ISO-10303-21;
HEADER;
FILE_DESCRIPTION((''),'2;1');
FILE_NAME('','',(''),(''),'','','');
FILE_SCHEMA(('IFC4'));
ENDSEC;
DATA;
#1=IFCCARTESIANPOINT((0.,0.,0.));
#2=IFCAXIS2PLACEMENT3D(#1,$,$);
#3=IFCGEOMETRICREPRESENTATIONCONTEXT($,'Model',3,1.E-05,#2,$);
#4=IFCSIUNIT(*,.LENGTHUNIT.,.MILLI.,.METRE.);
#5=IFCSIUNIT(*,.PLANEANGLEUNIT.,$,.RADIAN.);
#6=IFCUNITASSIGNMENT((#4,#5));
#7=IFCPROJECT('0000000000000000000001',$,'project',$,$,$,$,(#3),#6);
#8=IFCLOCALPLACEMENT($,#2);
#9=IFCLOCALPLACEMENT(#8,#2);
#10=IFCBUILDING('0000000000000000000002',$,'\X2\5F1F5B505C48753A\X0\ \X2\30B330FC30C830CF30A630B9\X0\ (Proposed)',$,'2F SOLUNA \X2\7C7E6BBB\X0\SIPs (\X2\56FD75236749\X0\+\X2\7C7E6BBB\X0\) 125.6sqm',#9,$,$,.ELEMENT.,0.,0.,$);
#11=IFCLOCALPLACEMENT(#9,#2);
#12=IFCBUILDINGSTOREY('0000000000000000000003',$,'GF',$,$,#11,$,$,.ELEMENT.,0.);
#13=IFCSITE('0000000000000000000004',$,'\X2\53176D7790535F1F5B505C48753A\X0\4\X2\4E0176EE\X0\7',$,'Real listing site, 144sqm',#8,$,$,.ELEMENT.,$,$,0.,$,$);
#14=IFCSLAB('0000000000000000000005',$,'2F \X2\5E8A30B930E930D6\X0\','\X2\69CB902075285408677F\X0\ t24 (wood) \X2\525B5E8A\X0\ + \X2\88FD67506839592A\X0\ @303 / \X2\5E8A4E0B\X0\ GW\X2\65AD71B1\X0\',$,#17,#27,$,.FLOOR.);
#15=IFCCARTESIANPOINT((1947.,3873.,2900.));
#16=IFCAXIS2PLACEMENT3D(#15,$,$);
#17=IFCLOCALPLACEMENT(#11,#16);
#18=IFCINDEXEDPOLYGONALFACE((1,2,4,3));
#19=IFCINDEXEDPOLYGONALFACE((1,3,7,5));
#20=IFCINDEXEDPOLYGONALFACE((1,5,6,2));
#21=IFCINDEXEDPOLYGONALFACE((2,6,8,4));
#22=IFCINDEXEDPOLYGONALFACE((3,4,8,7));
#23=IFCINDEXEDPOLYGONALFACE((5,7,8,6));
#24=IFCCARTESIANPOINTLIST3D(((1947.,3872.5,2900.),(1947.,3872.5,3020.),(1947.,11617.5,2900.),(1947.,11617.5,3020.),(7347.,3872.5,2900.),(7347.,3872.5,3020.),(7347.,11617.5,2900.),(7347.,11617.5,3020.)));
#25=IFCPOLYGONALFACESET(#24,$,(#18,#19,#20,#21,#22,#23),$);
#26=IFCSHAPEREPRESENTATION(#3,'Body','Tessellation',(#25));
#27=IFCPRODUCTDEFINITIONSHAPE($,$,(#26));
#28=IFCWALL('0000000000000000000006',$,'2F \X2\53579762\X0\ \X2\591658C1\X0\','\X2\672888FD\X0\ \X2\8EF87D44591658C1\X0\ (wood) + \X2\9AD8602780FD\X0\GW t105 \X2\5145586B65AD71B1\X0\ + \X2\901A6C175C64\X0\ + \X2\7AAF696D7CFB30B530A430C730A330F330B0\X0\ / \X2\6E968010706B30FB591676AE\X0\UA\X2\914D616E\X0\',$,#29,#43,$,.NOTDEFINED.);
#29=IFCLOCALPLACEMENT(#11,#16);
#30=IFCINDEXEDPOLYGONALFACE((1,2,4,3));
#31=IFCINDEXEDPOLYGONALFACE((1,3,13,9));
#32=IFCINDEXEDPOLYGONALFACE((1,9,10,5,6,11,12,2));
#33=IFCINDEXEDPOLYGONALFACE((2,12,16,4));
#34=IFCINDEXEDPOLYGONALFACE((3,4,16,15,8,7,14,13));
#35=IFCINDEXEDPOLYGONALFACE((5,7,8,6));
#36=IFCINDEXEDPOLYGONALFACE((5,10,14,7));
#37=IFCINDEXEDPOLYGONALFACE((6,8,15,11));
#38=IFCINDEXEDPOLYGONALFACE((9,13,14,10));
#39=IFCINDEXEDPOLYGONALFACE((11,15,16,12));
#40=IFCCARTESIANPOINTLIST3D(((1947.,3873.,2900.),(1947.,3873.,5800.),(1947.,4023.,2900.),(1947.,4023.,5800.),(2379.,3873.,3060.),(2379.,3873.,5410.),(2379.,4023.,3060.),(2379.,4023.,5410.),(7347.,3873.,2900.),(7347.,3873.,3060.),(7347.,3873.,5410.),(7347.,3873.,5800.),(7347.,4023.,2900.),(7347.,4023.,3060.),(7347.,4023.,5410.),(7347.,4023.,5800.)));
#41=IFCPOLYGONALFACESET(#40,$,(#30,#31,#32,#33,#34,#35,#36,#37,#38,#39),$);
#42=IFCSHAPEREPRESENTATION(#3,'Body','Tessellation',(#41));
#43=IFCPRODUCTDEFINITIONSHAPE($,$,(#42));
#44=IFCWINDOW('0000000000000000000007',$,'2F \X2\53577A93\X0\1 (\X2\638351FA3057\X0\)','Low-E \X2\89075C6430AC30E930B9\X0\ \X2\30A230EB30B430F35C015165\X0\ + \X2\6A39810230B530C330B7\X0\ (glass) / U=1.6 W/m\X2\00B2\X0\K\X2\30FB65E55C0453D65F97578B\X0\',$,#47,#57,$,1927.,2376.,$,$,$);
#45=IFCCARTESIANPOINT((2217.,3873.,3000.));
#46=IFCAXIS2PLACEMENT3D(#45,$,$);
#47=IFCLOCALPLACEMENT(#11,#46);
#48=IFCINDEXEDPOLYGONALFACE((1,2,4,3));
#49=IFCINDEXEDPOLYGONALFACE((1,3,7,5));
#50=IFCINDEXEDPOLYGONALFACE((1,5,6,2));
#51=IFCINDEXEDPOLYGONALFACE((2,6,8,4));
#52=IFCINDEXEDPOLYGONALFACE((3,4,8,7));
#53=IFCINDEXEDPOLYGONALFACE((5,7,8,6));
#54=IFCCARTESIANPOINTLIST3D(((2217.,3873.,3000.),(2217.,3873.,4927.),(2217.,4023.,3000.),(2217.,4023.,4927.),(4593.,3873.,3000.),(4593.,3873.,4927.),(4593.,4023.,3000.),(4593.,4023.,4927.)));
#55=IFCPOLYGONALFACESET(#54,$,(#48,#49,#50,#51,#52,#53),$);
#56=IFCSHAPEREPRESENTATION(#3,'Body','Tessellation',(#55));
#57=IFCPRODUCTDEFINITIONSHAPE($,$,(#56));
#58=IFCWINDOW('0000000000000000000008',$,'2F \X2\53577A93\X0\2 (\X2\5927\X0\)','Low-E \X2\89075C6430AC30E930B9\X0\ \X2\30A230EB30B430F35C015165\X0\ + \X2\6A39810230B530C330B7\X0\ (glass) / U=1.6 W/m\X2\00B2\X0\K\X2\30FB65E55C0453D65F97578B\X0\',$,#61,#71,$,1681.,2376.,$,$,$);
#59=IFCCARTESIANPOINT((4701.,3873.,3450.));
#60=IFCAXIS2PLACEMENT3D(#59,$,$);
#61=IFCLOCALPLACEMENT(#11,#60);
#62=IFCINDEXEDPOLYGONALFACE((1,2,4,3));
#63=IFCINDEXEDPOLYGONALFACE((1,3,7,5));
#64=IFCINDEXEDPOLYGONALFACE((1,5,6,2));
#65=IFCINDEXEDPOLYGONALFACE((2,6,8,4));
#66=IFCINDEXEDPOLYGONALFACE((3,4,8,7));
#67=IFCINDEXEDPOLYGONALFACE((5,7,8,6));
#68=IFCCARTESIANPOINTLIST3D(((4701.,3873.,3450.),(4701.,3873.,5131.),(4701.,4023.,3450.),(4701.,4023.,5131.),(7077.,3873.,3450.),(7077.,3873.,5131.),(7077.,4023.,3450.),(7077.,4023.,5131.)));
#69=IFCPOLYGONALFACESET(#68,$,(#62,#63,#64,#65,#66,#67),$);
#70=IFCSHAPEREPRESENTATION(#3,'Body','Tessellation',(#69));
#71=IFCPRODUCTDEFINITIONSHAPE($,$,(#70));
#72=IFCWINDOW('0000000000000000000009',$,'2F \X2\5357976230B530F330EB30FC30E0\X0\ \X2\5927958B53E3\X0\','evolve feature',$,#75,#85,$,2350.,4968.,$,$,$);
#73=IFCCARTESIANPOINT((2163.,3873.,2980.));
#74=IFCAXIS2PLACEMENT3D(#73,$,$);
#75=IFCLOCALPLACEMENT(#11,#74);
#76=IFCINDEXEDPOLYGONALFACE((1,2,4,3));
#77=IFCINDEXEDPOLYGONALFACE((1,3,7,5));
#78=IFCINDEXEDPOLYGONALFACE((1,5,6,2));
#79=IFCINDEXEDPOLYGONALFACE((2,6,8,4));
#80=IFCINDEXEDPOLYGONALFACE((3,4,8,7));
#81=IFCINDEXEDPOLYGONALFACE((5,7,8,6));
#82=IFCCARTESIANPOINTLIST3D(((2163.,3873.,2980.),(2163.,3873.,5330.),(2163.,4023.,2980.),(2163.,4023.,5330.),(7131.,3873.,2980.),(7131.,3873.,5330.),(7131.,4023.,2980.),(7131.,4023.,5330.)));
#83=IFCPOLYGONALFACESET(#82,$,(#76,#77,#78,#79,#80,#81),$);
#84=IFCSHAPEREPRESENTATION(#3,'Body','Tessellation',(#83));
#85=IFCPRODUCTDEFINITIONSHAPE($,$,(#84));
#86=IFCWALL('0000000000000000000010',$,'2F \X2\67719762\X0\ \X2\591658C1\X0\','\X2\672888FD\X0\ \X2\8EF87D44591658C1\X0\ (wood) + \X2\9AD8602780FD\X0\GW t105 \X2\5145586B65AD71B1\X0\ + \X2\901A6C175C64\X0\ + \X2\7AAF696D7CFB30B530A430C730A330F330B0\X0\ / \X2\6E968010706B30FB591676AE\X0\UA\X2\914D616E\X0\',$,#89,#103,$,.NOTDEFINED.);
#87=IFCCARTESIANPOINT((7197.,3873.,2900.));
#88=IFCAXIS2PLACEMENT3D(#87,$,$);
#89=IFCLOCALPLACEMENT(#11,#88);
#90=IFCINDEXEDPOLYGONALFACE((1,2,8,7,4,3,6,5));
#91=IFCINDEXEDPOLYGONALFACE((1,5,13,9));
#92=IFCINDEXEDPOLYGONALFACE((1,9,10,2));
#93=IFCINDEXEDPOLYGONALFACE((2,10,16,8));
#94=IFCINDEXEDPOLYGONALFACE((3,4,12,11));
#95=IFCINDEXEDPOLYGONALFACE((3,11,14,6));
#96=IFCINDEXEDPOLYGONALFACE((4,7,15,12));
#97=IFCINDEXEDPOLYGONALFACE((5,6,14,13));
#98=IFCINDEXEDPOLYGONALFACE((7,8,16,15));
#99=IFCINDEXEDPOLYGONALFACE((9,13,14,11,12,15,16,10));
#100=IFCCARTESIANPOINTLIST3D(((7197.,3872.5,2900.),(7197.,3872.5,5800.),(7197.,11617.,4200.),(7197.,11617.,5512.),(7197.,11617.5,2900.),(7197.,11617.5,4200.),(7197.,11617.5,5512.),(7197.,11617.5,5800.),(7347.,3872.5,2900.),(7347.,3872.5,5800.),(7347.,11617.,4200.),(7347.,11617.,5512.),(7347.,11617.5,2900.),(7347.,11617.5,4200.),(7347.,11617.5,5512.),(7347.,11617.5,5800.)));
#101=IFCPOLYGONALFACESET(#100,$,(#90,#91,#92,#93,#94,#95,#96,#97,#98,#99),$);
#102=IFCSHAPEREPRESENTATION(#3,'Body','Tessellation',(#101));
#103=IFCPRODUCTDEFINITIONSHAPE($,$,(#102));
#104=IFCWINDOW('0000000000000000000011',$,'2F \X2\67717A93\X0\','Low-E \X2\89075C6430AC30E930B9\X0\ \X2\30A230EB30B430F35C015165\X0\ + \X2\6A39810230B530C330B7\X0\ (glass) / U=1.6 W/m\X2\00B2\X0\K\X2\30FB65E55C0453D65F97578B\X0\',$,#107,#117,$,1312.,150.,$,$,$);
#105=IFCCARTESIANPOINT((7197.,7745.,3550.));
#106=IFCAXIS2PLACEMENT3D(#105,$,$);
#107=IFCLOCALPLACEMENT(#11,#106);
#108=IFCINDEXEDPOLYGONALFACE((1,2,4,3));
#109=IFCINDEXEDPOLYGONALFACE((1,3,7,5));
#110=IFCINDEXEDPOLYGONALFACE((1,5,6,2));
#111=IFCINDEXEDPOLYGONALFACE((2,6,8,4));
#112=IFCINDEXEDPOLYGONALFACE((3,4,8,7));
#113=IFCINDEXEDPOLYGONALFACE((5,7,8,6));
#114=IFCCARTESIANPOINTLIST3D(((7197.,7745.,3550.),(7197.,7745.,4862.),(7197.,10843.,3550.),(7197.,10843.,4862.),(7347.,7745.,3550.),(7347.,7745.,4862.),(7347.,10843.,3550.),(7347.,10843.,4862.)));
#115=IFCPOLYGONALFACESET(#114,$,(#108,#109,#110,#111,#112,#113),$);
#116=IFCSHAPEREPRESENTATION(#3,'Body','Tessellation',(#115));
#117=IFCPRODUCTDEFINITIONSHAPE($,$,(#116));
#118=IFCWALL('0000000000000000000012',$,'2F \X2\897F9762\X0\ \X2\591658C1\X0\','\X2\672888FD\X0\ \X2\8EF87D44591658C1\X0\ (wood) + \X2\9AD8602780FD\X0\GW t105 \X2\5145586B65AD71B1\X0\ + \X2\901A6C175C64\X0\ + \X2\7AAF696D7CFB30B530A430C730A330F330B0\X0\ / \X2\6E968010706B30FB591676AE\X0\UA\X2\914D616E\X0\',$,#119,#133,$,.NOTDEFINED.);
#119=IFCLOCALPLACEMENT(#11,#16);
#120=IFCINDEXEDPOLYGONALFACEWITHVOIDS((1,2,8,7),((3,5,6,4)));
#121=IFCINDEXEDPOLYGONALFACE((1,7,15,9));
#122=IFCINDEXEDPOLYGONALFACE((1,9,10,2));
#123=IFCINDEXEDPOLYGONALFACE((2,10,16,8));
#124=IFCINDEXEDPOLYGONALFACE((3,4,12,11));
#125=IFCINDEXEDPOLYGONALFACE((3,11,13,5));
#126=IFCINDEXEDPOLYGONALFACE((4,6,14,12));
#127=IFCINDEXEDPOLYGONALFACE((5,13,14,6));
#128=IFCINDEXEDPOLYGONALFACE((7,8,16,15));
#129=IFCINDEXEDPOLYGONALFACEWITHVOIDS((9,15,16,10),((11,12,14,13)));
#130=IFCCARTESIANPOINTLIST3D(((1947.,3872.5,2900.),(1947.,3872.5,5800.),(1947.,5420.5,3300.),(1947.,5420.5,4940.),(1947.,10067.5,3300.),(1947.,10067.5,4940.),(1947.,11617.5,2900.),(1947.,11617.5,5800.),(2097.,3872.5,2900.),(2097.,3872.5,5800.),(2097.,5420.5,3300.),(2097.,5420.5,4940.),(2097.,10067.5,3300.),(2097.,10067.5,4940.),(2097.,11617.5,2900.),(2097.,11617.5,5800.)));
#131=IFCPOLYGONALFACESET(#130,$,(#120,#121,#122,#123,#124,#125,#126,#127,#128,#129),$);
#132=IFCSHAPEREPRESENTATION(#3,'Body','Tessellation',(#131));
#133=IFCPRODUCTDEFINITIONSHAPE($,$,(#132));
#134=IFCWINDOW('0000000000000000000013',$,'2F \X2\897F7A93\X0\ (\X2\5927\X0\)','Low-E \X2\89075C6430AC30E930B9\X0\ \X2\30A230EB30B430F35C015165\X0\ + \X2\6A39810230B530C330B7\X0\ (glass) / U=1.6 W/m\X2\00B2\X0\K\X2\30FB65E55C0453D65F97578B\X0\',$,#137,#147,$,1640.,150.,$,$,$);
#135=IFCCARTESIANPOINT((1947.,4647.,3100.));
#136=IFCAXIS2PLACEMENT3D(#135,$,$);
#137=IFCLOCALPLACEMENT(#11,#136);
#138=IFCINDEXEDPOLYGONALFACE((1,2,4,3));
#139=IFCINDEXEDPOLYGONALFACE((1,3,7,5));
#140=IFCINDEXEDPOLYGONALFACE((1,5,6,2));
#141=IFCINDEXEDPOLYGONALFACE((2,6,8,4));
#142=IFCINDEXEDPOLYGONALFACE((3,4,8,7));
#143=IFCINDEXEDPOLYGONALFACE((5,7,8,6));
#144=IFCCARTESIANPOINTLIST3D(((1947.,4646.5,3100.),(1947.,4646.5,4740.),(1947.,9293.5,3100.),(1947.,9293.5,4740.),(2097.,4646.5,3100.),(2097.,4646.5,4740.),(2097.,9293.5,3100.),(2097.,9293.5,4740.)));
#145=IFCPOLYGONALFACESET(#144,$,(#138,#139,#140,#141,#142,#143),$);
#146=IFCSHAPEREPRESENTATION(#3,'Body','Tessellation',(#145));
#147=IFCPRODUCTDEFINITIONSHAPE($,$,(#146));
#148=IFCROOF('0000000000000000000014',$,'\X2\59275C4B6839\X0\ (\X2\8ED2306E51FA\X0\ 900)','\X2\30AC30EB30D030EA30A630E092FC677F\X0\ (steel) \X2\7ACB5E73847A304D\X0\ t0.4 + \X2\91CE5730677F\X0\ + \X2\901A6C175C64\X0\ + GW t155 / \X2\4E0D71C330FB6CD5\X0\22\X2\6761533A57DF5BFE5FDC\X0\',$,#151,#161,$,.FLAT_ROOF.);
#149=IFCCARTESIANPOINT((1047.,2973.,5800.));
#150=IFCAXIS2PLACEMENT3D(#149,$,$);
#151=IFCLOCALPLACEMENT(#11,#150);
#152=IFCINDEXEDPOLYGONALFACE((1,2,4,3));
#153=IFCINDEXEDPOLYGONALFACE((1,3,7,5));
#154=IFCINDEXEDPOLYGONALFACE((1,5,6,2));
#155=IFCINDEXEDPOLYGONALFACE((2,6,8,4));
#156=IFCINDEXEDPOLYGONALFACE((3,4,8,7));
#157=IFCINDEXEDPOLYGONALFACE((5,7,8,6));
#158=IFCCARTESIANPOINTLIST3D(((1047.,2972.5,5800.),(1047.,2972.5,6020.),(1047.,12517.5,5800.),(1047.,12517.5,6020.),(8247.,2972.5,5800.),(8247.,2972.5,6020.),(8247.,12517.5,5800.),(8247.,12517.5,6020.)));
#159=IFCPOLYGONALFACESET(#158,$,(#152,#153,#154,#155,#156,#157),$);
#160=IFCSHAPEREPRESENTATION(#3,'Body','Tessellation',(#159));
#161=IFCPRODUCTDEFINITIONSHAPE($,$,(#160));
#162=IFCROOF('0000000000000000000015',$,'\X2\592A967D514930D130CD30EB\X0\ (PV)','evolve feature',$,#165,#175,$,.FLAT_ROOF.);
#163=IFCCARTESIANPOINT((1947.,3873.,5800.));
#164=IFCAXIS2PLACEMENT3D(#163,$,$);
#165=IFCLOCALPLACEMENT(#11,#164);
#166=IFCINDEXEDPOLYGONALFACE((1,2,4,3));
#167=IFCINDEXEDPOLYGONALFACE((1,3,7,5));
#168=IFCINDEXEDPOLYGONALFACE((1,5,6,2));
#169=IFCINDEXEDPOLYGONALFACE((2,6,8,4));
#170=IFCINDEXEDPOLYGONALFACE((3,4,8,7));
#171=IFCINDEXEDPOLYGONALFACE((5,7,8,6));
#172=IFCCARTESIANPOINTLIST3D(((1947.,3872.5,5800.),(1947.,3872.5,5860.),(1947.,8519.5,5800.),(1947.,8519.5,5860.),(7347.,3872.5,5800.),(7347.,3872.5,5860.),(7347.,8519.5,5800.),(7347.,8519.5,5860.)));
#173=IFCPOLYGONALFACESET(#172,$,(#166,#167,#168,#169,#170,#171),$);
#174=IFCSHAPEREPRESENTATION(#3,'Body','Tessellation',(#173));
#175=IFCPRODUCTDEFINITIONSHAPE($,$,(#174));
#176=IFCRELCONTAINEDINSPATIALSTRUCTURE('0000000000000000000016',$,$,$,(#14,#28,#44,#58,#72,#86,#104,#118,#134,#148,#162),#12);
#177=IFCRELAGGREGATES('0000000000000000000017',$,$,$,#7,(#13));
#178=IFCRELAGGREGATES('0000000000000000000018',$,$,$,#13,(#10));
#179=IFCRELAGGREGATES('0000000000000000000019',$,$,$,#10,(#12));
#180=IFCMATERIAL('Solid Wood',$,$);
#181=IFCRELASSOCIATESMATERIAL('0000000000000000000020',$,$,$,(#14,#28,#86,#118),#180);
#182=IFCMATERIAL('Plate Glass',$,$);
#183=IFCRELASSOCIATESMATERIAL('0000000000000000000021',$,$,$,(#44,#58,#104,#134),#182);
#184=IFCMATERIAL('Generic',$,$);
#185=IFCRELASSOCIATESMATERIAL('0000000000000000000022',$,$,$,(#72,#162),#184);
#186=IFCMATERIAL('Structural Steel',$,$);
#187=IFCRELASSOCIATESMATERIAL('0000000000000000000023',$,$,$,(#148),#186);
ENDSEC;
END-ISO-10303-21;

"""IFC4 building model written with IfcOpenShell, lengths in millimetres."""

from ifc_helpers import new_model, si_unit, frame, frame_2d, origin, place, context, project, spatial, rectangle, extrude, material, element, fill, save


model = new_model("IFC4")

# Units and contexts
model_context = context("Model", 3, precision=1e-05, world=origin())
ifc_project = project(units=[si_unit("LENGTHUNIT", "METRE", prefix="MILLI"), si_unit("PLANEANGLEUNIT", "RADIAN")], contexts=[model_context])

# Site, building, storey
site_placement = place(None, origin())
site = spatial("IfcSite", under=ifc_project, at=site_placement, Name="北海道弟子屈町4丁目7", ObjectType="Real listing site, 144sqm", CompositionType="ELEMENT", RefElevation=0.0)
building_placement = place(site_placement, origin())
building = spatial("IfcBuilding", under=site, at=building_placement, Name="弟子屈町 コートハウス (Proposed)", ObjectType="2F SOLUNA 籾殻SIPs (国産杉+籾殻) 125.6sqm", CompositionType="ELEMENT", ElevationOfRefHeight=0.0, ElevationOfTerrain=0.0)
storey_placement = place(building_placement, origin())
storey = spatial("IfcBuildingStorey", under=building, at=storey_placement, Name="GF", CompositionType="ELEMENT", Elevation=0.0)

# Slab
ifc_material_1 = material(Name="Solid Wood")
slab_placement = place(storey_placement, frame((1947.0, 3873.0, 2900.0)))
element("IfcSlab", 1, at=slab_placement, inside=storey, material=ifc_material_1, Name="2F 床スラブ", Description="構造用合板 t24 (wood) 剛床 + 製材根太 @303 / 床下 GW断熱", PredefinedType="FLOOR", context=model_context, shape_type="SweptSolid", body=[
    extrude(rectangle(XDim=5400.0, YDim=7745.0, at=frame_2d((2700.0, 3872.0))), frame((1947.0, 3873.0, 2900.0)), (0.0, 0.0, 1.0), 120.0),
])

# Wall, openings, windows
wall_1_placement = place(storey_placement, frame((1947.0, 3873.0, 2900.0)))
wall_1 = element("IfcWall", 2, at=wall_1_placement, inside=storey, material=ifc_material_1, Name="2F 南面 外壁", Description="木製 軸組外壁 (wood) + 高性能GW t105 充填断熱 + 通気層 + 窯業系サイディング / 準耐火・外皮UA配慮", PredefinedType="NOTDEFINED", context=model_context, shape_type="SweptSolid", body=[
    extrude(rectangle(XDim=5400.0, YDim=150.0, at=frame_2d((2700.0, 75.0))), frame((1947.0, 3873.0, 2900.0)), (0.0, 0.0, 1.0), 2900.0),
])
opening_1_placement = place(storey_placement, frame((2217.0, 3873.0, 3000.0)))
opening_1 = element("IfcOpeningElement", 3, at=opening_1_placement, cuts=wall_1, PredefinedType="NOTDEFINED", context=model_context, shape_type="SweptSolid", body=[
    extrude(rectangle(XDim=2376.0, YDim=150.0, at=frame_2d((1188.0, 75.0))), frame((2217.0, 3873.0, 3000.0)), (0.0, 0.0, 1.0), 1927.0),
])
opening_2_placement = place(storey_placement, frame((4701.0, 3873.0, 3450.0)))
opening_2 = element("IfcOpeningElement", 4, at=opening_2_placement, cuts=wall_1, PredefinedType="NOTDEFINED", context=model_context, shape_type="SweptSolid", body=[
    extrude(rectangle(XDim=2376.0, YDim=150.0, at=frame_2d((1188.0, 75.0))), frame((4701.0, 3873.0, 3450.0)), (0.0, 0.0, 1.0), 1681.0),
])
opening_3_placement = place(storey_placement, frame((2163.0, 3873.0, 2980.0)))
opening_3 = element("IfcOpeningElement", 5, at=opening_3_placement, cuts=wall_1, PredefinedType="NOTDEFINED", context=model_context, shape_type="SweptSolid", body=[
    extrude(rectangle(XDim=4968.0, YDim=150.0, at=frame_2d((2484.0, 75.0))), frame((2163.0, 3873.0, 2980.0)), (0.0, 0.0, 1.0), 2350.0),
])
ifc_material_2 = material(Name="Plate Glass")
window_1_placement = place(storey_placement, frame((2217.0, 3873.0, 3000.0)))
window_1 = element("IfcWindow", 6, at=window_1_placement, inside=storey, material=ifc_material_2, Name="2F 南窓1 (掃出し)", Description="Low-E 複層ガラス アルゴン封入 + 樹脂サッシ (glass) / U=1.6 W/m²K・日射取得型", OverallHeight=1927.0, OverallWidth=2376.0, context=model_context, shape_type="SweptSolid", body=[
    extrude(rectangle(XDim=2376.0, YDim=150.0, at=frame_2d((1188.0, 75.0))), frame((2217.0, 3873.0, 3000.0)), (0.0, 0.0, 1.0), 1927.0),
])
fill(opening_1, window_1)
window_2_placement = place(storey_placement, frame((4701.0, 3873.0, 3450.0)))
window_2 = element("IfcWindow", 7, at=window_2_placement, inside=storey, material=ifc_material_2, Name="2F 南窓2 (大)", Description="Low-E 複層ガラス アルゴン封入 + 樹脂サッシ (glass) / U=1.6 W/m²K・日射取得型", OverallHeight=1681.0, OverallWidth=2376.0, context=model_context, shape_type="SweptSolid", body=[
    extrude(rectangle(XDim=2376.0, YDim=150.0, at=frame_2d((1188.0, 75.0))), frame((4701.0, 3873.0, 3450.0)), (0.0, 0.0, 1.0), 1681.0),
])
fill(opening_2, window_2)
ifc_material_3 = material(Name="Generic")
window_3_placement = place(storey_placement, frame((2163.0, 3873.0, 2980.0)))
window_3 = element("IfcWindow", 8, at=window_3_placement, inside=storey, material=ifc_material_3, Name="2F 南面サンルーム 大開口", Description="evolve feature", OverallHeight=2350.0, OverallWidth=4968.0, context=model_context, shape_type="SweptSolid", body=[
    extrude(rectangle(XDim=4968.0, YDim=150.0, at=frame_2d((2484.0, 75.0))), frame((2163.0, 3873.0, 2980.0)), (0.0, 0.0, 1.0), 2350.0),
])
fill(opening_3, window_3)

# Walls, openings, windows
wall_2_placement = place(storey_placement, frame((7197.0, 3873.0, 2900.0)))
wall_2 = element("IfcWall", 9, at=wall_2_placement, inside=storey, material=ifc_material_1, Name="2F 東面 外壁", Description="木製 軸組外壁 (wood) + 高性能GW t105 充填断熱 + 通気層 + 窯業系サイディング / 準耐火・外皮UA配慮", PredefinedType="NOTDEFINED", context=model_context, shape_type="SweptSolid", body=[
    extrude(rectangle(XDim=150.0, YDim=7745.0, at=frame_2d((75.0, 3872.0))), frame((7197.0, 3873.0, 2900.0)), (0.0, 0.0, 1.0), 2900.0),
])
opening_4_placement = place(storey_placement, frame((7197.0, 7745.0, 3550.0)))
opening_4 = element("IfcOpeningElement", 10, at=opening_4_placement, cuts=wall_2, PredefinedType="NOTDEFINED", context=model_context, shape_type="SweptSolid", body=[
    extrude(rectangle(XDim=150.0, YDim=3098.0, at=frame_2d((75.0, 1549.0))), frame((7197.0, 7745.0, 3550.0)), (0.0, 0.0, 1.0), 1312.0),
])
window_4_placement = place(storey_placement, frame((7197.0, 7745.0, 3550.0)))
window_4 = element("IfcWindow", 11, at=window_4_placement, inside=storey, material=ifc_material_2, Name="2F 東窓", Description="Low-E 複層ガラス アルゴン封入 + 樹脂サッシ (glass) / U=1.6 W/m²K・日射取得型", OverallHeight=1312.0, OverallWidth=150.0, context=model_context, shape_type="SweptSolid", body=[
    extrude(rectangle(XDim=150.0, YDim=3098.0, at=frame_2d((75.0, 1549.0))), frame((7197.0, 7745.0, 3550.0)), (0.0, 0.0, 1.0), 1312.0),
])
fill(opening_4, window_4)
wall_3_placement = place(storey_placement, frame((1947.0, 3873.0, 2900.0)))
wall_3 = element("IfcWall", 12, at=wall_3_placement, inside=storey, material=ifc_material_1, Name="2F 西面 外壁", Description="木製 軸組外壁 (wood) + 高性能GW t105 充填断熱 + 通気層 + 窯業系サイディング / 準耐火・外皮UA配慮", PredefinedType="NOTDEFINED", context=model_context, shape_type="SweptSolid", body=[
    extrude(rectangle(XDim=150.0, YDim=7745.0, at=frame_2d((75.0, 3872.0))), frame((1947.0, 3873.0, 2900.0)), (0.0, 0.0, 1.0), 2900.0),
])
opening_5_placement = place(storey_placement, frame((1947.0, 4647.0, 3100.0)))
opening_5 = element("IfcOpeningElement", 13, at=opening_5_placement, cuts=wall_3, PredefinedType="NOTDEFINED", context=model_context, shape_type="SweptSolid", body=[
    extrude(rectangle(XDim=150.0, YDim=4647.0, at=frame_2d((75.0, 2323.0))), frame((1947.0, 4647.0, 3100.0)), (0.0, 0.0, 1.0), 1640.0),
])
window_5_placement = place(storey_placement, frame((1947.0, 4647.0, 3100.0)))
window_5 = element("IfcWindow", 14, at=window_5_placement, inside=storey, material=ifc_material_2, Name="2F 西窓 (大)", Description="Low-E 複層ガラス アルゴン封入 + 樹脂サッシ (glass) / U=1.6 W/m²K・日射取得型", OverallHeight=1640.0, OverallWidth=150.0, context=model_context, shape_type="SweptSolid", body=[
    extrude(rectangle(XDim=150.0, YDim=4647.0, at=frame_2d((75.0, 2323.0))), frame((1947.0, 4647.0, 3100.0)), (0.0, 0.0, 1.0), 1640.0),
])
fill(opening_5, window_5)

# Roofs
ifc_material_4 = material(Name="Structural Steel")
roof_1_placement = place(storey_placement, frame((1047.0, 2973.0, 5800.0)))
element("IfcRoof", 15, at=roof_1_placement, inside=storey, material=ifc_material_4, Name="大屋根 (軒の出 900)", Description="ガルバリウム鋼板 (steel) 立平葺き t0.4 + 野地板 + 通気層 + GW t155 / 不燃・法22条区域対応", PredefinedType="FLAT_ROOF", context=model_context, shape_type="SweptSolid", body=[
    extrude(rectangle(XDim=7200.0, YDim=9545.0, at=frame_2d((3600.0, 4772.0))), frame((1047.0, 2973.0, 5800.0)), (0.0, 0.0, 1.0), 220.0),
])
roof_2_placement = place(storey_placement, frame((1947.0, 3873.0, 5800.0)))
element("IfcRoof", 16, at=roof_2_placement, inside=storey, material=ifc_material_3, Name="太陽光パネル (PV)", Description="evolve feature", PredefinedType="FLAT_ROOF", context=model_context, shape_type="SweptSolid", body=[
    extrude(rectangle(XDim=5400.0, YDim=4647.0, at=frame_2d((2700.0, 2323.0))), frame((1947.0, 3873.0, 5800.0)), (0.0, 0.0, 1.0), 60.0),
])

save(model, "model.ifc")
